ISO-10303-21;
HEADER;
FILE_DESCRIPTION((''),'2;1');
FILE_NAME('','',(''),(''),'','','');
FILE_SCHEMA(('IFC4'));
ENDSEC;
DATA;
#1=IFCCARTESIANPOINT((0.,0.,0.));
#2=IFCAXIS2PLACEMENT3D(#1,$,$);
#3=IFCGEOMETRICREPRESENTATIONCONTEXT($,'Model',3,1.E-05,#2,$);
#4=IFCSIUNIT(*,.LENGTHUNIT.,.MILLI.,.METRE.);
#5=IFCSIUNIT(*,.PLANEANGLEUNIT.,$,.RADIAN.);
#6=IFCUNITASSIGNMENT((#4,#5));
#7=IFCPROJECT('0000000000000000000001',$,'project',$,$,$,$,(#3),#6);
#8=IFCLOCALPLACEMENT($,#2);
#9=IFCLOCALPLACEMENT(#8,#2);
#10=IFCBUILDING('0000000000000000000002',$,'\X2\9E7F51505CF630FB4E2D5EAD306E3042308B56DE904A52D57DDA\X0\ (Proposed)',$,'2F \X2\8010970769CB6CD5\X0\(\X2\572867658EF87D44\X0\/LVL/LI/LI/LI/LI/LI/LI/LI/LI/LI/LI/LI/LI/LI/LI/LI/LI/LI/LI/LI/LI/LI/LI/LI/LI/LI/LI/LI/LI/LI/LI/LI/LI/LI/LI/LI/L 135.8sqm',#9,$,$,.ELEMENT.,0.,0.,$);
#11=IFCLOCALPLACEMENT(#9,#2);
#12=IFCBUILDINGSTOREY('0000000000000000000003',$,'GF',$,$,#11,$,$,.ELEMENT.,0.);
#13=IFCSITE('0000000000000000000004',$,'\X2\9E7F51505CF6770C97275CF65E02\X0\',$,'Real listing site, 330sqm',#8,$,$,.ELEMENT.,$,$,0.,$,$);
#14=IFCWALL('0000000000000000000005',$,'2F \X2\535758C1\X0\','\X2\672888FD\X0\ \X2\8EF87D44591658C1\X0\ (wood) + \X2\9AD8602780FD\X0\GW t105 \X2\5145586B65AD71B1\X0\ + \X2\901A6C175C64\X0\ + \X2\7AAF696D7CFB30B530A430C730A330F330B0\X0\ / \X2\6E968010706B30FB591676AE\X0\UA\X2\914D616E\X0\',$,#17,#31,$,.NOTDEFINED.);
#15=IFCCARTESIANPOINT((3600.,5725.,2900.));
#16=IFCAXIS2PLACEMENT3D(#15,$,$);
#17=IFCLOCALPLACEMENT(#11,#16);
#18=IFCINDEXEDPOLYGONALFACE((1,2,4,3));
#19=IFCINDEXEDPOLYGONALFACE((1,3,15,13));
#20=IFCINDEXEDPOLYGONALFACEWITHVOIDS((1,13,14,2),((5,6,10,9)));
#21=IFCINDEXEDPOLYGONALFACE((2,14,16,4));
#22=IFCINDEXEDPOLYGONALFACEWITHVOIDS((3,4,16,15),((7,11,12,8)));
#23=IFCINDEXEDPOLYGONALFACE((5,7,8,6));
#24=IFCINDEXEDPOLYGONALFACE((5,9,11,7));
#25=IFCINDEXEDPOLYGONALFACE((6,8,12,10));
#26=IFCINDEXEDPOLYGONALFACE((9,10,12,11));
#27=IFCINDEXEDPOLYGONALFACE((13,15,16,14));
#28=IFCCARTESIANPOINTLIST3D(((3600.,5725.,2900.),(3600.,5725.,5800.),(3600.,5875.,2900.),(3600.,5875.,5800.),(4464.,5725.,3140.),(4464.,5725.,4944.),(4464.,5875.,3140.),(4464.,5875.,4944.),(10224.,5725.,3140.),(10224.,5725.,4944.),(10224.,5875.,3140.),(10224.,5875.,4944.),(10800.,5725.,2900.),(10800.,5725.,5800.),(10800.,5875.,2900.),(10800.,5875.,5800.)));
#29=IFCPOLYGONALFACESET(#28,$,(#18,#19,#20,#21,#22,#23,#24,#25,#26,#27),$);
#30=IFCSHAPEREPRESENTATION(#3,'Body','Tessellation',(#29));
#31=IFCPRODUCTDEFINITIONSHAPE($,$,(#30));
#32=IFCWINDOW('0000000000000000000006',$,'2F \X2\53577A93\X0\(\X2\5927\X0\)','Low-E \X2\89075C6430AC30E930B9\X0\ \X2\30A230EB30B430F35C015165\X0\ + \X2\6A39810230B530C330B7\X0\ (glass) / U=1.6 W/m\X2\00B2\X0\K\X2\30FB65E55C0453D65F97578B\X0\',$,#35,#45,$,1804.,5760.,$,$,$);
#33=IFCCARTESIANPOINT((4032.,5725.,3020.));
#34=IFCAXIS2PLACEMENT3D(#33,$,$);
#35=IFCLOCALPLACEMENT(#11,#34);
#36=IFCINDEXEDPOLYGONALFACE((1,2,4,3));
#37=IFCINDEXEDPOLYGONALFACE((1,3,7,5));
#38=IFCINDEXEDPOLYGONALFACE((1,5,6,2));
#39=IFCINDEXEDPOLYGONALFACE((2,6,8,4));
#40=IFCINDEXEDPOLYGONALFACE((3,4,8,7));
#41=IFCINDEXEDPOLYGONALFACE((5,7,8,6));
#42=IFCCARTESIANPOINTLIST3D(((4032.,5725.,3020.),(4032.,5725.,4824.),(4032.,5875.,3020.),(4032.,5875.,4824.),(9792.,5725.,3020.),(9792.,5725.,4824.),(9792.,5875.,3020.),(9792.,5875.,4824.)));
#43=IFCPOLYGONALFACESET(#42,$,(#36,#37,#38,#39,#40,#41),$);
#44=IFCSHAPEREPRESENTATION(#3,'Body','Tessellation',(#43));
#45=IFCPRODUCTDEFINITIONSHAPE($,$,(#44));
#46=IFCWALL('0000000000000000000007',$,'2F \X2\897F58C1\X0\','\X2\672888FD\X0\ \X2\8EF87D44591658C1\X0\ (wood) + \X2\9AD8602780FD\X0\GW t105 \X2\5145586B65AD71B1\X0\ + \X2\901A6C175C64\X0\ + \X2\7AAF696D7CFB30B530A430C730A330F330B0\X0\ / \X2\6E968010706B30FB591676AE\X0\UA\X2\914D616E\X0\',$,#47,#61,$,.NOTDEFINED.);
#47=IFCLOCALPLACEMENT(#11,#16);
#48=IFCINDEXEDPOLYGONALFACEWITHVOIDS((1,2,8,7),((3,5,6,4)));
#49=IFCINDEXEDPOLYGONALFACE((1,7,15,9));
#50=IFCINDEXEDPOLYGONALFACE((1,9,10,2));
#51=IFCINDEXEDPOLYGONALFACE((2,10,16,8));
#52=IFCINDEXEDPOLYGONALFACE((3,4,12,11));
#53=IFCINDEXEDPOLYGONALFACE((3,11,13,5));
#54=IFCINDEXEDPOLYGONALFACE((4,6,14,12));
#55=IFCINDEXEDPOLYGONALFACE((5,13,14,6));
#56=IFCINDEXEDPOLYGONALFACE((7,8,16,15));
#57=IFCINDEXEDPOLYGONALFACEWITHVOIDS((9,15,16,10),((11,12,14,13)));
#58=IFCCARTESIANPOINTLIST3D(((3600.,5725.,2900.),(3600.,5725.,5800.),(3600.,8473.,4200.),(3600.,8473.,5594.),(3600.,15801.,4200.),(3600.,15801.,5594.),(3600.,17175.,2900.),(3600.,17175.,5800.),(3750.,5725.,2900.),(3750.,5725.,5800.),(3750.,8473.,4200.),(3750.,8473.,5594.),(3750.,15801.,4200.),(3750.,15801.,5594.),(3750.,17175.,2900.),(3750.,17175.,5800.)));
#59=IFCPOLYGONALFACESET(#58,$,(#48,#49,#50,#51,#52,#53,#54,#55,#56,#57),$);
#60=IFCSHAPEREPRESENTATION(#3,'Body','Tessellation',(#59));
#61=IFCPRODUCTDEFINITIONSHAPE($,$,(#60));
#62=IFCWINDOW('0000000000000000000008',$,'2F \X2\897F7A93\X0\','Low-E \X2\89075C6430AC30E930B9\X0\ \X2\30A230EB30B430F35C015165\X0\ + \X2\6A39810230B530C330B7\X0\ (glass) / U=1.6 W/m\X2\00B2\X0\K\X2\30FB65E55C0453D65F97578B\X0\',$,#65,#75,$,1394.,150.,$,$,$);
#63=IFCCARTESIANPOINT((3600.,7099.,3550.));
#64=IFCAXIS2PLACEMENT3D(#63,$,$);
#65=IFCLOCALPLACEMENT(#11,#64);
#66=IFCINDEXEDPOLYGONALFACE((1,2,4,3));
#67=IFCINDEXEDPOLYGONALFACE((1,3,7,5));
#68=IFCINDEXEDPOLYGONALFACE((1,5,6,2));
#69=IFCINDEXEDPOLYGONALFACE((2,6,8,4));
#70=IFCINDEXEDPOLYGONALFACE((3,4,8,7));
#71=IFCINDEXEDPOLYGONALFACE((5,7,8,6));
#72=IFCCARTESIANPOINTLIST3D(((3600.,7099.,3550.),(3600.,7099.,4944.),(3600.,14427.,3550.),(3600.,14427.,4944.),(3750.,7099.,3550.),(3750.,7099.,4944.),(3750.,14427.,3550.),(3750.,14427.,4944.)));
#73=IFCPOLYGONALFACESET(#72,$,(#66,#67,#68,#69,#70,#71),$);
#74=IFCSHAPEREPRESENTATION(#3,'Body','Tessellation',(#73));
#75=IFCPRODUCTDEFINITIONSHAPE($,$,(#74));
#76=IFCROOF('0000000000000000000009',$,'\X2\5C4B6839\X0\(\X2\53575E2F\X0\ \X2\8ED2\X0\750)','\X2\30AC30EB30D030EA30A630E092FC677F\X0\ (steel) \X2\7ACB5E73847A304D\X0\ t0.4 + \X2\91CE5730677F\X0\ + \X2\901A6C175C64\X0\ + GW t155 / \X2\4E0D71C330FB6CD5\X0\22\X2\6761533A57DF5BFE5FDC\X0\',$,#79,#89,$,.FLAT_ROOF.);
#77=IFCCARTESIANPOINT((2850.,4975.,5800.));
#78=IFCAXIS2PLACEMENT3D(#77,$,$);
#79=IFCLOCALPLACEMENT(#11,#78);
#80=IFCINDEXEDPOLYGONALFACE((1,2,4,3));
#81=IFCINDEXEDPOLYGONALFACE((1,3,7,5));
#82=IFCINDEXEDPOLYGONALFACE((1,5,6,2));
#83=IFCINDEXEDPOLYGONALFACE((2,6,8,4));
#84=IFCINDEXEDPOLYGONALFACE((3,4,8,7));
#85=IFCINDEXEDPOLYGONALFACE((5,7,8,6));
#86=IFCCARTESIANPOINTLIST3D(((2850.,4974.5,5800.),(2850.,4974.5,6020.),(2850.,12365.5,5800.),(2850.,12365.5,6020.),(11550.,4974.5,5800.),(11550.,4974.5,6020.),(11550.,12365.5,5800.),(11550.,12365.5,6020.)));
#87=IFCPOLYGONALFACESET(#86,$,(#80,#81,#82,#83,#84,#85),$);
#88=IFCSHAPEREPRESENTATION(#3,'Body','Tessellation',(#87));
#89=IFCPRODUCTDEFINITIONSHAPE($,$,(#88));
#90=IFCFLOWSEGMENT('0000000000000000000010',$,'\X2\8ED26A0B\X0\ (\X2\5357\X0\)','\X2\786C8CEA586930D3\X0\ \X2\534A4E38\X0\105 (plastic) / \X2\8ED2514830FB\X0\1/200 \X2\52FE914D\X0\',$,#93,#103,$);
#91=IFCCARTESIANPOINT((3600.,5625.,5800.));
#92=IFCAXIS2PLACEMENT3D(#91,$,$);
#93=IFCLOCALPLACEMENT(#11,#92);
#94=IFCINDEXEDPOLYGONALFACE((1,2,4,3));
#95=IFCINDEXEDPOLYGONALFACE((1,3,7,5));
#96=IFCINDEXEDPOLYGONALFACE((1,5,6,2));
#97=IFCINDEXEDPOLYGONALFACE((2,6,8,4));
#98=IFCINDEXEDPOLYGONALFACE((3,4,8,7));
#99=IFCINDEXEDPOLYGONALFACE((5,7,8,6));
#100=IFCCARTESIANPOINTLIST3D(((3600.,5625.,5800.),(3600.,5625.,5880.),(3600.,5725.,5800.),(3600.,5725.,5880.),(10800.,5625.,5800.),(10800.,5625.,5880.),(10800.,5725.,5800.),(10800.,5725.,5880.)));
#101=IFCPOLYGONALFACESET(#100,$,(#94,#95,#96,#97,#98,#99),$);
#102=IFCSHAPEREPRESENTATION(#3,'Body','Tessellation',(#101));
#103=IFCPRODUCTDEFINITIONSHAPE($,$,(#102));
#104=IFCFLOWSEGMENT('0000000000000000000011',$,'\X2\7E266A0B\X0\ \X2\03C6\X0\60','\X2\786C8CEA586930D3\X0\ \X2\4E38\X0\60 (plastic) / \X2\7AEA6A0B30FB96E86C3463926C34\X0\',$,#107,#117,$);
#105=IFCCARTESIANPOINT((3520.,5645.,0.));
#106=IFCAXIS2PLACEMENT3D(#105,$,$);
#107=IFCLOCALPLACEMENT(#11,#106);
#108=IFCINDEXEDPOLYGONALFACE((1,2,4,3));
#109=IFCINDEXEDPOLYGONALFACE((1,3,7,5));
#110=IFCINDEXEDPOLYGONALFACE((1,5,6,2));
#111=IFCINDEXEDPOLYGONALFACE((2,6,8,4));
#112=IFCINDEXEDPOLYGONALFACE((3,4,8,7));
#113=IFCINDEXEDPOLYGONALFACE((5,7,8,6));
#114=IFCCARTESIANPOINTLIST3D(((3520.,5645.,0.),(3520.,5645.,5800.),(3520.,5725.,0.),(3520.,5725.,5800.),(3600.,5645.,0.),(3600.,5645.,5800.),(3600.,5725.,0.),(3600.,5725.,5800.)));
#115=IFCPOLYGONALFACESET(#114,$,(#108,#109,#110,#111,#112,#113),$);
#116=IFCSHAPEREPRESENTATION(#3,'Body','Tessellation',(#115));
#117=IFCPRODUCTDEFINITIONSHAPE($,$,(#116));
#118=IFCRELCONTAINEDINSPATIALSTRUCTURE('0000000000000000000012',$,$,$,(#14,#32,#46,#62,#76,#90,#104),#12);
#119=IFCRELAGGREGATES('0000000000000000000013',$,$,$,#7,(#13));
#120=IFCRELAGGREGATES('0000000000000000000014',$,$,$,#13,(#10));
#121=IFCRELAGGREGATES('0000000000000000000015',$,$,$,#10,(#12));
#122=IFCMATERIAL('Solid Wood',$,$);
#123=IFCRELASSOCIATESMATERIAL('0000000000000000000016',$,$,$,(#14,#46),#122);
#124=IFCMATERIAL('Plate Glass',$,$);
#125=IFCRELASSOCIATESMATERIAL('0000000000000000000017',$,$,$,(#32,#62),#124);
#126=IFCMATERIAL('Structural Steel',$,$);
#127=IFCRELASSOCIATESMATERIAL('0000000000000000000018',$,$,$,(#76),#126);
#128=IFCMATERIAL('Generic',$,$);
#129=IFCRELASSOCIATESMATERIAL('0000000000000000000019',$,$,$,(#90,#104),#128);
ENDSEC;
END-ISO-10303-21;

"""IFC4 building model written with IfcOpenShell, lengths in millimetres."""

from ifc_helpers import new_model, si_unit, frame, frame_2d, origin, place, context, project, spatial, rectangle, extrude, material, element, fill, save


model = new_model("IFC4")

# Units and contexts
model_context = context("Model", 3, precision=1e-05, world=origin())
ifc_project = project(units=[si_unit("LENGTHUNIT", "METRE", prefix="MILLI"), si_unit("PLANEANGLEUNIT", "RADIAN")], contexts=[model_context])

# Site, building, storey
site_placement = place(None, origin())
site = spatial("IfcSite", under=ifc_project, at=site_placement, Name="鹿児島県霧島市", ObjectType="Real listing site, 330sqm", CompositionType="ELEMENT", RefElevation=0.0)
building_placement = place(site_placement, origin())
building = spatial("IfcBuilding", under=site, at=building_placement, Name="鹿児島・中庭のある回遊動線 (Proposed)", ObjectType="2F 耐震構法(在来軸組/LVL/LI/LI/LI/LI/LI/LI/LI/LI/LI/LI/LI/LI/LI/LI/LI/LI/LI/LI/LI/LI/LI/LI/LI/LI/LI/LI/LI/LI/LI/LI/LI/LI/LI/LI/LI/L 135.8sqm", CompositionType="ELEMENT", ElevationOfRefHeight=0.0, ElevationOfTerrain=0.0)
storey_placement = place(building_placement, origin())
storey = spatial("IfcBuildingStorey", under=building, at=storey_placement, Name="GF", CompositionType="ELEMENT", Elevation=0.0)

# Shared definitions
ifc_material_1 = material(Name="Solid Wood")

# Shared definitions
ifc_material_2 = material(Name="Plate Glass")

# Walls, openings, windows
wall_1_placement = place(storey_placement, frame((3600.0, 5725.0, 2900.0)))
wall_1 = element("IfcWall", 1, at=wall_1_placement, inside=storey, material=ifc_material_1, Name="2F 南壁", Description="木製 軸組外壁 (wood) + 高性能GW t105 充填断熱 + 通気層 + 窯業系サイディング / 準耐火・外皮UA配慮", PredefinedType="NOTDEFINED", context=model_context, shape_type="SweptSolid", body=[
    extrude(rectangle(XDim=7200.0, YDim=150.0, at=frame_2d((3600.0, 75.0))), frame((3600.0, 5725.0, 2900.0)), (0.0, 0.0, 1.0), 2900.0),
])
opening_1_placement = place(storey_placement, frame((4032.0, 5725.0, 3020.0)))
opening_1 = element("IfcOpeningElement", 2, at=opening_1_placement, cuts=wall_1, PredefinedType="NOTDEFINED", context=model_context, shape_type="SweptSolid", body=[
    extrude(rectangle(XDim=5760.0, YDim=150.0, at=frame_2d((2880.0, 75.0))), frame((4032.0, 5725.0, 3020.0)), (0.0, 0.0, 1.0), 1804.0),
])
window_1_placement = place(storey_placement, frame((4032.0, 5725.0, 3020.0)))
window_1 = element("IfcWindow", 3, at=window_1_placement, inside=storey, material=ifc_material_2, Name="2F 南窓(大)", Description="Low-E 複層ガラス アルゴン封入 + 樹脂サッシ (glass) / U=1.6 W/m²K・日射取得型", OverallHeight=1804.0, OverallWidth=5760.0, context=model_context, shape_type="SweptSolid", body=[
    extrude(rectangle(XDim=5760.0, YDim=150.0, at=frame_2d((2880.0, 75.0))), frame((4032.0, 5725.0, 3020.0)), (0.0, 0.0, 1.0), 1804.0),
])
fill(opening_1, window_1)
wall_2_placement = place(storey_placement, frame((3600.0, 5725.0, 2900.0)))
wall_2 = element("IfcWall", 4, at=wall_2_placement, inside=storey, material=ifc_material_1, Name="2F 西壁", Description="木製 軸組外壁 (wood) + 高性能GW t105 充填断熱 + 通気層 + 窯業系サイディング / 準耐火・外皮UA配慮", PredefinedType="NOTDEFINED", context=model_context, shape_type="SweptSolid", body=[
    extrude(rectangle(XDim=150.0, YDim=11450.0, at=frame_2d((75.0, 5725.0))), frame((3600.0, 5725.0, 2900.0)), (0.0, 0.0, 1.0), 2900.0),
])
opening_2_placement = place(storey_placement, frame((3600.0, 7099.0, 3550.0)))
opening_2 = element("IfcOpeningElement", 5, at=opening_2_placement, cuts=wall_2, PredefinedType="NOTDEFINED", context=model_context, shape_type="SweptSolid", body=[
    extrude(rectangle(XDim=150.0, YDim=7328.0, at=frame_2d((75.0, 3664.0))), frame((3600.0, 7099.0, 3550.0)), (0.0, 0.0, 1.0), 1394.0),
])
window_2_placement = place(storey_placement, frame((3600.0, 7099.0, 3550.0)))
window_2 = element("IfcWindow", 6, at=window_2_placement, inside=storey, material=ifc_material_2, Name="2F 西窓", Description="Low-E 複層ガラス アルゴン封入 + 樹脂サッシ (glass) / U=1.6 W/m²K・日射取得型", OverallHeight=1394.0, OverallWidth=150.0, context=model_context, shape_type="SweptSolid", body=[
    extrude(rectangle(XDim=150.0, YDim=7328.0, at=frame_2d((75.0, 3664.0))), frame((3600.0, 7099.0, 3550.0)), (0.0, 0.0, 1.0), 1394.0),
])
fill(opening_2, window_2)

# Roof
ifc_material_3 = material(Name="Structural Steel")
for number, where, name in (
    (7, (2850.0, 4975.0, 5800.0), "屋根(南帯 軒750)"),
):
    element("IfcRoof", number, at=place(storey_placement, frame(where)), inside=storey, material=ifc_material_3, Name=name, Description="ガルバリウム鋼板 (steel) 立平葺き t0.4 + 野地板 + 通気層 + GW t155 / 不燃・法22条区域対応", PredefinedType="FLAT_ROOF", context=model_context, shape_type="SweptSolid", body=[
        extrude(rectangle(XDim=8700.0, YDim=7391.0, at=frame_2d((4350.0, 3695.0))), frame((2850.0, 4975.0, 5800.0)), (0.0, 0.0, 1.0), 220.0),
    ])

# Flow segments
ifc_material_4 = material(Name="Generic")
flow_segment_1_placement = place(storey_placement, frame((3600.0, 5625.0, 5800.0)))
element("IfcFlowSegment", 8, at=flow_segment_1_placement, inside=storey, material=ifc_material_4, Name="軒樋 (南)", Description="硬質塩ビ 半丸105 (plastic) / 軒先・1/200 勾配", context=model_context, shape_type="SweptSolid", body=[
    extrude(rectangle(XDim=7200.0, YDim=100.0, at=frame_2d((3600.0, 50.0))), frame((3600.0, 5625.0, 5800.0)), (0.0, 0.0, 1.0), 80.0),
])
flow_segment_2_placement = place(storey_placement, frame((3520.0, 5645.0, 0.0)))
element("IfcFlowSegment", 9, at=flow_segment_2_placement, inside=storey, material=ifc_material_4, Name="縦樋 φ60", Description="硬質塩ビ 丸60 (plastic) / 竪樋・雨水排水", context=model_context, shape_type="SweptSolid", body=[
    extrude(rectangle(XDim=80.0, YDim=80.0, at=frame_2d((40.0, 40.0))), frame((3520.0, 5645.0, 0.0)), (0.0, 0.0, 1.0), 5800.0),
])

save(model, "model.ifc")
